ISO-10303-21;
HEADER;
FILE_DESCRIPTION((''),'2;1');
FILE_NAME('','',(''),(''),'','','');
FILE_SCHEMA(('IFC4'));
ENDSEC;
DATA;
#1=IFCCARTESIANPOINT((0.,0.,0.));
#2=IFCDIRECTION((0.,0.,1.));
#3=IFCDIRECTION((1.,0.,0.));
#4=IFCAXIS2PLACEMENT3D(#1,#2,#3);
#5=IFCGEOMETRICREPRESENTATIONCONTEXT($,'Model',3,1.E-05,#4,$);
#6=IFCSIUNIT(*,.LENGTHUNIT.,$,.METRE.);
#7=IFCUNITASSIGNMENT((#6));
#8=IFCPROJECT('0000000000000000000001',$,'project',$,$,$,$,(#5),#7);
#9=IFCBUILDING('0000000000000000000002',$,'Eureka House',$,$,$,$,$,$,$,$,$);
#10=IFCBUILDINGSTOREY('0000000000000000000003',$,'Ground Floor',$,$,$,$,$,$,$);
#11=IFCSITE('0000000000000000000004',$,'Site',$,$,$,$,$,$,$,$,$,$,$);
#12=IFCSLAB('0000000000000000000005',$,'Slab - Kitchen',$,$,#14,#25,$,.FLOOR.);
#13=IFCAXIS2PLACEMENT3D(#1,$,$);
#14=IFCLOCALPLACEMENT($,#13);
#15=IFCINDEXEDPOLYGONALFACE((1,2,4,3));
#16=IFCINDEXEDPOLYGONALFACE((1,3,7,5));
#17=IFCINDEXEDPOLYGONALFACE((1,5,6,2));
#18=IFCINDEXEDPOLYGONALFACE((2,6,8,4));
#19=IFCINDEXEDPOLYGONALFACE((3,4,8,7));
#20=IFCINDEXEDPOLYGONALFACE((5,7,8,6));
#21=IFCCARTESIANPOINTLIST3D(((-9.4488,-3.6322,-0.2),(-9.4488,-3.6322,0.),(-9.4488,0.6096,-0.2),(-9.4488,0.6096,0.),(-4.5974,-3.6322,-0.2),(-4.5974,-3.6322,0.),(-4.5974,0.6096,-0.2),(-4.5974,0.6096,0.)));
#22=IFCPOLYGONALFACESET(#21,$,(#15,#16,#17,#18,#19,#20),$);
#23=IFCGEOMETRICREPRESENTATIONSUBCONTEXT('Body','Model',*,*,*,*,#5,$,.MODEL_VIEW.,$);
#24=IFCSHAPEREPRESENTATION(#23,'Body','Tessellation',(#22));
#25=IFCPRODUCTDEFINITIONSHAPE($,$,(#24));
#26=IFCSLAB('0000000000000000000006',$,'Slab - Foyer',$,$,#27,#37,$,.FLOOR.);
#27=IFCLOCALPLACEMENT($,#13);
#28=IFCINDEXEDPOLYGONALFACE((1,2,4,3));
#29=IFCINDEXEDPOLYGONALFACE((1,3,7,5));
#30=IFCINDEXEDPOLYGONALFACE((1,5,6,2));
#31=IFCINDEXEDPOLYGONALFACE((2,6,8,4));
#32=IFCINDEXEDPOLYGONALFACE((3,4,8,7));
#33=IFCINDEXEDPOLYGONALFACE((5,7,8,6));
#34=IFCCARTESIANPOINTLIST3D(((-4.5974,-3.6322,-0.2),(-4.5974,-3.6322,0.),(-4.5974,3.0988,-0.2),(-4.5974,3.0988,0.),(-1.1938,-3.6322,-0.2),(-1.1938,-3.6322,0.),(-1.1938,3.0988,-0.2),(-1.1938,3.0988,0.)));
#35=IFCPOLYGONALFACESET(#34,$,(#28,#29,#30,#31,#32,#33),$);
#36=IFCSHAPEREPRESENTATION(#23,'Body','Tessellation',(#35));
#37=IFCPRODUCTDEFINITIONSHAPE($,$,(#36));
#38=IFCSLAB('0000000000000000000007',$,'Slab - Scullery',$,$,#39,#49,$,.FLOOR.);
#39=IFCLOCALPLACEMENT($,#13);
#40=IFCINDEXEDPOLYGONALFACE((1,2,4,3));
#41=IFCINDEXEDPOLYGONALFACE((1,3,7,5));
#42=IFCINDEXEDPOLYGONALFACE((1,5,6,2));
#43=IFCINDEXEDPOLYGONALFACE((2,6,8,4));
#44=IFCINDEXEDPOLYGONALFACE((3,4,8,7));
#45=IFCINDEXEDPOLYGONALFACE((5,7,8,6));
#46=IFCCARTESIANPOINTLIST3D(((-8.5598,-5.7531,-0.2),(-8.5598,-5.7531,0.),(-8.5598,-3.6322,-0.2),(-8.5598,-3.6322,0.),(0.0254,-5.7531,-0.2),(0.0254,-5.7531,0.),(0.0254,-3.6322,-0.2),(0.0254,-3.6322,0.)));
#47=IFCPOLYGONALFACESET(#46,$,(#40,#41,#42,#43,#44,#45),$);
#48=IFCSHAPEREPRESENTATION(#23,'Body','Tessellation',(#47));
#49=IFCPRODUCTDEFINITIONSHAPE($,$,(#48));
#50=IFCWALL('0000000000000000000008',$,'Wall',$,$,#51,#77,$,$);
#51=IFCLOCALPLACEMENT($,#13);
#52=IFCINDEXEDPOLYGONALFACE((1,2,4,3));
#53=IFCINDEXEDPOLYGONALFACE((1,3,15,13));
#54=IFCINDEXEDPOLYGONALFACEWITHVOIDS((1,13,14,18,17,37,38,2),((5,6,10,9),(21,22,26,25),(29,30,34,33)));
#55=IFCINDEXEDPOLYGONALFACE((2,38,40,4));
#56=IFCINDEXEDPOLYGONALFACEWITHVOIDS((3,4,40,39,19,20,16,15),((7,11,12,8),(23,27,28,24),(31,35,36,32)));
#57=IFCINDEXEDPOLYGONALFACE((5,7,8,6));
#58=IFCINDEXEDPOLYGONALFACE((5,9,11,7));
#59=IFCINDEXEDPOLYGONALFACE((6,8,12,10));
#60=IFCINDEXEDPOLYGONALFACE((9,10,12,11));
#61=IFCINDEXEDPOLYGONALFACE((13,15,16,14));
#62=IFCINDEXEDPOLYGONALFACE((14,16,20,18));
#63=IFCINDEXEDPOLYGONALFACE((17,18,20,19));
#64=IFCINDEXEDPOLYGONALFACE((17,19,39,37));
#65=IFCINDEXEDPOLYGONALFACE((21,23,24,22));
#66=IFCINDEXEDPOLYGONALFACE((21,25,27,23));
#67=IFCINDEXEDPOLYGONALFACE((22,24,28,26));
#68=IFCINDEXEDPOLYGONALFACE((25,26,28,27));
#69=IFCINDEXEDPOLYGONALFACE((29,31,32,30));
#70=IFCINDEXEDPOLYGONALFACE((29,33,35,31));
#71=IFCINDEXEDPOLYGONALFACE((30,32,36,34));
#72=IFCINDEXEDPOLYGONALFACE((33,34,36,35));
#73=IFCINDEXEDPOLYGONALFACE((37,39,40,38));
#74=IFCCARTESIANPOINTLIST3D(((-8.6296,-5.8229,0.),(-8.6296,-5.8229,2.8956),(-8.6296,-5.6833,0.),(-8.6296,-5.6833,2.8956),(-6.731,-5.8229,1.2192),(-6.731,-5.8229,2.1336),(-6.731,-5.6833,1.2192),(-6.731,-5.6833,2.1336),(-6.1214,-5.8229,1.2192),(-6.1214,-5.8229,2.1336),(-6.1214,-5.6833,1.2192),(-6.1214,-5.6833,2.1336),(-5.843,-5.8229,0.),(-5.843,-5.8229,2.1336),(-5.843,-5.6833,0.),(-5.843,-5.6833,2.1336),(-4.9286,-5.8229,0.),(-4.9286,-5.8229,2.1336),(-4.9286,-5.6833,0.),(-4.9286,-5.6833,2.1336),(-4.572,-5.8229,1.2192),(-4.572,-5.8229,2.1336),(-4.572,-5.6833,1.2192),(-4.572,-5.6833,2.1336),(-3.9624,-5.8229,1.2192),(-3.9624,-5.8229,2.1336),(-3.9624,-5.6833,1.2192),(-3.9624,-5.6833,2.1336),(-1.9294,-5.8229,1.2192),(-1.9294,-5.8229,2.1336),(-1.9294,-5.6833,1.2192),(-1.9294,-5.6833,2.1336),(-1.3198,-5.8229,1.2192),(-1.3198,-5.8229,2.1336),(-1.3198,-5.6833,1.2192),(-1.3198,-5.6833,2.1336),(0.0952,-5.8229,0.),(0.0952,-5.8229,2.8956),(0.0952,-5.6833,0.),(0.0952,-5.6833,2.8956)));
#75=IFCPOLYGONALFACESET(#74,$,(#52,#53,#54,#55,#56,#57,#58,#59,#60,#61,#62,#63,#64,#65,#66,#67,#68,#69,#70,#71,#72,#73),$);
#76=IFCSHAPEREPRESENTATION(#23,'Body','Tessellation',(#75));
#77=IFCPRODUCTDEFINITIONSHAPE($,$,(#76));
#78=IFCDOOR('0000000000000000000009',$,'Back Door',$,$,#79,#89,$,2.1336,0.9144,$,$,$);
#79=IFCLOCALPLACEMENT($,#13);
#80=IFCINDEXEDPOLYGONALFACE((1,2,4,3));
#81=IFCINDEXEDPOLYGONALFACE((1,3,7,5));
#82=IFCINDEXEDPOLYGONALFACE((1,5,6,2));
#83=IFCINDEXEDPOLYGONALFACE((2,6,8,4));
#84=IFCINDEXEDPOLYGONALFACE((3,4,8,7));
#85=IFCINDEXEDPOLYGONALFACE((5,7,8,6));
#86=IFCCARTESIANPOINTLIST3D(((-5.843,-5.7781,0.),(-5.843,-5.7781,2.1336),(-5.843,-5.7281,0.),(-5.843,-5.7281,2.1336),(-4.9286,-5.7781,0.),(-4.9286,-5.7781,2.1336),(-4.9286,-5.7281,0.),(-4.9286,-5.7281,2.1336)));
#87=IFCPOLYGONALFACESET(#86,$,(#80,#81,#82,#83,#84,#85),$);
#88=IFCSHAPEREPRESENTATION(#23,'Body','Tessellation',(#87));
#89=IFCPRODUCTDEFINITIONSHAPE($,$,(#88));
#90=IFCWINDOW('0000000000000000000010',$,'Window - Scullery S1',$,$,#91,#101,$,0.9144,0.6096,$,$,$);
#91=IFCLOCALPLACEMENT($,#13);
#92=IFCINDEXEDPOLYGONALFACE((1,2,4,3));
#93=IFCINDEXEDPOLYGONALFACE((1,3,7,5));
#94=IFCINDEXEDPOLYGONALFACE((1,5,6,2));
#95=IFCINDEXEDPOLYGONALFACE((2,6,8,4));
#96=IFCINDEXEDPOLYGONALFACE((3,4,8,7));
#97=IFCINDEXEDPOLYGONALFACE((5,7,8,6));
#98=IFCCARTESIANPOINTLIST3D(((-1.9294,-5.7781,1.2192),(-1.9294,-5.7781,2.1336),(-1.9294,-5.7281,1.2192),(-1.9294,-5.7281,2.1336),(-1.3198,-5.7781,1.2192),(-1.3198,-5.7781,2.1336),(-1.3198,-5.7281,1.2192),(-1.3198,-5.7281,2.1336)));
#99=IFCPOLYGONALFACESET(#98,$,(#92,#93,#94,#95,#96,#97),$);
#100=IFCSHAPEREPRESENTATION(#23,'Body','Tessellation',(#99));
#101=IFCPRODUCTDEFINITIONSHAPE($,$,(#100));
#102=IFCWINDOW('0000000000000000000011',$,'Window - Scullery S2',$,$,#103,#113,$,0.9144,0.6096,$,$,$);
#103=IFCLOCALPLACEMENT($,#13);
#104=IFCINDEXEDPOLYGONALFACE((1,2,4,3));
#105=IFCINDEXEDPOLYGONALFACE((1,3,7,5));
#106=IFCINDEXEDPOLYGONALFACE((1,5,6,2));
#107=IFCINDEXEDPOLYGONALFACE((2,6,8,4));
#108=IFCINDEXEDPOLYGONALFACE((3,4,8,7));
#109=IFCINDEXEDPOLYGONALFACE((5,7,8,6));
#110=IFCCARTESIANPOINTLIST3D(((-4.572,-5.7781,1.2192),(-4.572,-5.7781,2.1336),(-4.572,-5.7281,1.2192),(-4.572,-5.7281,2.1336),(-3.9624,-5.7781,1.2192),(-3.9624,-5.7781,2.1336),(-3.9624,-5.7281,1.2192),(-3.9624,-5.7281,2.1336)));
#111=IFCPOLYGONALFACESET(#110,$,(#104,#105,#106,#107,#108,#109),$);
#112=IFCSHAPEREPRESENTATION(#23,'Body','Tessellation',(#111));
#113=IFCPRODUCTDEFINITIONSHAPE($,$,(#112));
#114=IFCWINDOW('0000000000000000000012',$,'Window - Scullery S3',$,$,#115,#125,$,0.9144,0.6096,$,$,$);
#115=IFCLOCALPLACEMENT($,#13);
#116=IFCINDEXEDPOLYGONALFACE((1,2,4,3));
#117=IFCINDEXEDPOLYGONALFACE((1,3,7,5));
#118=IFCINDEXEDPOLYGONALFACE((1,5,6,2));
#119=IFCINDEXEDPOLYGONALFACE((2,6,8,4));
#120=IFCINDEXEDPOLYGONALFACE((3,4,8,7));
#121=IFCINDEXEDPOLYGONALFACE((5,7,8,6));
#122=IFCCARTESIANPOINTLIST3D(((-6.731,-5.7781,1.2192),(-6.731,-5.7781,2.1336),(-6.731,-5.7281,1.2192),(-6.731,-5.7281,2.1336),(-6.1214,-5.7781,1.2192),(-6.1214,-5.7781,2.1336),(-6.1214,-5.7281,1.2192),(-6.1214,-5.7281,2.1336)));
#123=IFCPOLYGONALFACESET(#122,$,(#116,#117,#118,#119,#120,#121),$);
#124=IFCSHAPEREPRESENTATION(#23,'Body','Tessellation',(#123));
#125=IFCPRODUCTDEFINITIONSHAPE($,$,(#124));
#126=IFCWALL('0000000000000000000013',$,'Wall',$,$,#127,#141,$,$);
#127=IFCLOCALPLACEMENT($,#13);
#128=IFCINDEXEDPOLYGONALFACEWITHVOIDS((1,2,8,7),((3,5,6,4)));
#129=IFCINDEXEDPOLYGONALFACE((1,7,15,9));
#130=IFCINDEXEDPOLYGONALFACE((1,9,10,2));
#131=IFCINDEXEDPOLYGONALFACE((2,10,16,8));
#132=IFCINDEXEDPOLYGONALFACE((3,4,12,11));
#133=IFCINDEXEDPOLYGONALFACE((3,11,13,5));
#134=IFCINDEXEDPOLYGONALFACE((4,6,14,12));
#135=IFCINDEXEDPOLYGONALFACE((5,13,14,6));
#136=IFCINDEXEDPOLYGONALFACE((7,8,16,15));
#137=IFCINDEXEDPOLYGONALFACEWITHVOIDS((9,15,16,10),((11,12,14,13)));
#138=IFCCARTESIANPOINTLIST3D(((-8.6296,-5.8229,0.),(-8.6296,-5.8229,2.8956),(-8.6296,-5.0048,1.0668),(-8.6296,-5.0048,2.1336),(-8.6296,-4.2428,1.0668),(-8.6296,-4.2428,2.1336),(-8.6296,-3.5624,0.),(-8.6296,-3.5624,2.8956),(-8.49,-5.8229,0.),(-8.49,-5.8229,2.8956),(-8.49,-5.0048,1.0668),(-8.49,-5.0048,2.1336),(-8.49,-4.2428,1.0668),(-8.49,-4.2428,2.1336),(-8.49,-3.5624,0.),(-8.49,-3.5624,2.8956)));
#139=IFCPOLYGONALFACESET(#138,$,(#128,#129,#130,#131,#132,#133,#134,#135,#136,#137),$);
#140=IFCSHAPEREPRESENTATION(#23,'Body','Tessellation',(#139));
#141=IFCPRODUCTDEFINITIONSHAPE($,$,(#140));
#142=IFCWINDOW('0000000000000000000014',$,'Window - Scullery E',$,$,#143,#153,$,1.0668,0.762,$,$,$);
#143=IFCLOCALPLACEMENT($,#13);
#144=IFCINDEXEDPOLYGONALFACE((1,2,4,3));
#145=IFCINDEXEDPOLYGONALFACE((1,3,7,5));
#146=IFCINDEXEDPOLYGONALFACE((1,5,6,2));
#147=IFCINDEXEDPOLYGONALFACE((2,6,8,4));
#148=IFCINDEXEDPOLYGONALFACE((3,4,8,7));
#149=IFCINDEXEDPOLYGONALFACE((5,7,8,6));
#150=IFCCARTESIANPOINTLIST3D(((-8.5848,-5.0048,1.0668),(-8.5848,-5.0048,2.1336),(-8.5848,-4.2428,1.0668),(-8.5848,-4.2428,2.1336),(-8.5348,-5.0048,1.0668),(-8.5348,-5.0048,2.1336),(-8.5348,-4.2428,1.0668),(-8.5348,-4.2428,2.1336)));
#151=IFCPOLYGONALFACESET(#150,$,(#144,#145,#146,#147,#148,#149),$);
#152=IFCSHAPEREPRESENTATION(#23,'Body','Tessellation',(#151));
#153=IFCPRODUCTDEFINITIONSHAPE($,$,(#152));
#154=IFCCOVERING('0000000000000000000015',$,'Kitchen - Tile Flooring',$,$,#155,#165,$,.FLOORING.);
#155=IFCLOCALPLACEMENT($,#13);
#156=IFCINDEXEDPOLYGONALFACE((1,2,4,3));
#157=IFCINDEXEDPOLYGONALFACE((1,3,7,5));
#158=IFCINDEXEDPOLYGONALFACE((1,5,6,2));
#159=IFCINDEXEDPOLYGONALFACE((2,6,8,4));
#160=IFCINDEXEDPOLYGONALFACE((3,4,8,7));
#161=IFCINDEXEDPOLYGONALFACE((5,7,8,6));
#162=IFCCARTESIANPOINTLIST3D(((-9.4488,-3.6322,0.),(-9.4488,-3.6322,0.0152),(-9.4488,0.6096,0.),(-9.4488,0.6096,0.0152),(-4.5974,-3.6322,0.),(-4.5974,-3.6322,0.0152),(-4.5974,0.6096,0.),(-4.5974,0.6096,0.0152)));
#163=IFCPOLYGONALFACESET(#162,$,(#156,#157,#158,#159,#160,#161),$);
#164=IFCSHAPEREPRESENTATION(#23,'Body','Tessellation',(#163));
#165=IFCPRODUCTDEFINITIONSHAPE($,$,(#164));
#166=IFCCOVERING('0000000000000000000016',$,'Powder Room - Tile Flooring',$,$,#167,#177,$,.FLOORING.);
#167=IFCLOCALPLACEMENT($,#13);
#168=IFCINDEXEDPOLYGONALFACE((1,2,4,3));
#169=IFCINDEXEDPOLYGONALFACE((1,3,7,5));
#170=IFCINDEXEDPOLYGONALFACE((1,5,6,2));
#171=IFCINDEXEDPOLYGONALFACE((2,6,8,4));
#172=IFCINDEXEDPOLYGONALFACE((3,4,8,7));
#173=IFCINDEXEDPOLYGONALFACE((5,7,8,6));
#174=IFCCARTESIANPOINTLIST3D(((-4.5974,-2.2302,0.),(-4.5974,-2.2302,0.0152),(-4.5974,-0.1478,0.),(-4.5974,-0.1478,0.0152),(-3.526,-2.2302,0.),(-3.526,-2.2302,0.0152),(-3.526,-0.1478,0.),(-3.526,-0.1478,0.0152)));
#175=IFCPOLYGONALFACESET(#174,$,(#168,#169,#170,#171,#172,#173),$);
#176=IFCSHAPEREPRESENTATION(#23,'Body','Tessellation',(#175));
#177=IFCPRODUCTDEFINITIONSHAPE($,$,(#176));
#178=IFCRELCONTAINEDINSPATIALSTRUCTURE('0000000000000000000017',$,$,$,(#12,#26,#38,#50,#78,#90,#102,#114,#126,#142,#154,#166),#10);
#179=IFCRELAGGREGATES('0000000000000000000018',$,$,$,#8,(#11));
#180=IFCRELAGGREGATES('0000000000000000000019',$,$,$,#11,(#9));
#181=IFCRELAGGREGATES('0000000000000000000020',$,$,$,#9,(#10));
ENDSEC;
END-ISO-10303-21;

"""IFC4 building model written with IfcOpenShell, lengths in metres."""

from ifc_helpers import new_model, si_unit, frame, origin, origin_with_axes, origin_2d, place, context, subcontext, project, spatial, rectangle, extrude, element, fill, save


model = new_model("IFC4")

# Units and contexts
model_context = context("Model", 3, precision=1e-05, world=origin_with_axes())
body_context = subcontext(model_context, "Body", "Model", "MODEL_VIEW")
ifc_project = project(units=[si_unit("LENGTHUNIT", "METRE")], contexts=[model_context])

# Site, building, storey
site = spatial("IfcSite", under=ifc_project, Name="Site")
building = spatial("IfcBuilding", under=site, Name="Eureka House")
storey = spatial("IfcBuildingStorey", under=building, Name="Ground Floor")

# Slabs
slab_1_placement = place(None, frame((-7.0231, -1.5113, -0.2), z_axis=(0.0, 0.0, 1.0), x_axis=(1.0, 0.0, 0.0)))
element("IfcSlab", 1, at=slab_1_placement, inside=storey, Name="Slab - Kitchen", PredefinedType="FLOOR", context=body_context, shape_type="SweptSolid", body=[
    extrude(rectangle(XDim=4.8514, YDim=4.2418, at=origin_2d()), origin(), (0.0, 0.0, 1.0), 0.2),
])
slab_2_placement = place(None, frame((-2.8956, -0.2667, -0.2), z_axis=(0.0, 0.0, 1.0), x_axis=(1.0, 0.0, 0.0)))
element("IfcSlab", 2, at=slab_2_placement, inside=storey, Name="Slab - Foyer", PredefinedType="FLOOR", context=body_context, shape_type="SweptSolid", body=[
    extrude(rectangle(XDim=3.4036, YDim=6.731, at=origin_2d()), origin(), (0.0, 0.0, 1.0), 0.2),
])
slab_3_placement = place(None, frame((-4.2672, -4.6927, -0.2), z_axis=(0.0, 0.0, 1.0), x_axis=(1.0, 0.0, 0.0)))
element("IfcSlab", 3, at=slab_3_placement, inside=storey, Name="Slab - Scullery", PredefinedType="FLOOR", context=body_context, shape_type="SweptSolid", body=[
    extrude(rectangle(XDim=8.5852, YDim=2.1209, at=origin_2d()), origin(), (0.0, 0.0, 1.0), 0.2),
])

# Wall, openings, door, windows
wall_1_placement = place(None, frame((-4.2672, -5.7531, 0.0), z_axis=(0.0, 0.0, 1.0), x_axis=(1.0, 0.0, 0.0)))
wall_1 = element("IfcWall", 4, at=wall_1_placement, inside=storey, Name="Wall", context=body_context, shape_type="SweptSolid", body=[
    extrude(rectangle(XDim=8.7249, YDim=0.1397, at=origin_2d()), origin(), (0.0, 0.0, 1.0), 2.8956),
])
opening_1_placement = place(wall_1_placement, frame((-1.1186, 0.0, 0.0), z_axis=(0.0, 0.0, 1.0), x_axis=(1.0, 0.0, 0.0)))
opening_1 = element("IfcOpeningElement", 5, at=opening_1_placement, cuts=wall_1, context=body_context, shape_type="SweptSolid", body=[
    extrude(rectangle(XDim=0.9144, YDim=0.2397, at=origin_2d()), origin(), (0.0, 0.0, 1.0), 2.1336),
])
opening_2_placement = place(wall_1_placement, frame((2.6426, 0.0, 1.2192), z_axis=(0.0, 0.0, 1.0), x_axis=(1.0, 0.0, 0.0)))
opening_2 = element("IfcOpeningElement", 6, at=opening_2_placement, cuts=wall_1, context=body_context, shape_type="SweptSolid", body=[
    extrude(rectangle(XDim=0.6096, YDim=0.2397, at=origin_2d()), origin(), (0.0, 0.0, 1.0), 0.9144),
])
opening_3_placement = place(wall_1_placement, frame((0.0, 0.0, 1.2192), z_axis=(0.0, 0.0, 1.0), x_axis=(1.0, 0.0, 0.0)))
opening_3 = element("IfcOpeningElement", 7, at=opening_3_placement, cuts=wall_1, context=body_context, shape_type="SweptSolid", body=[
    extrude(rectangle(XDim=0.6096, YDim=0.2397, at=origin_2d()), origin(), (0.0, 0.0, 1.0), 0.9144),
])
opening_4_placement = place(wall_1_placement, frame((-2.159, 0.0, 1.2192), z_axis=(0.0, 0.0, 1.0), x_axis=(1.0, 0.0, 0.0)))
opening_4 = element("IfcOpeningElement", 8, at=opening_4_placement, cuts=wall_1, context=body_context, shape_type="SweptSolid", body=[
    extrude(rectangle(XDim=0.6096, YDim=0.2397, at=origin_2d()), origin(), (0.0, 0.0, 1.0), 0.9144),
])
door_placement = place(opening_1_placement, origin_with_axes())
door = element("IfcDoor", 9, at=door_placement, inside=storey, Name="Back Door", OverallHeight=2.1336, OverallWidth=0.9144, context=body_context, shape_type="SweptSolid", body=[
    extrude(rectangle(XDim=0.9144, YDim=0.05, at=origin_2d()), origin(), (0.0, 0.0, 1.0), 2.1336),
])
fill(opening_1, door)
window_1_placement = place(opening_2_placement, origin_with_axes())
window_1 = element("IfcWindow", 10, at=window_1_placement, inside=storey, Name="Window - Scullery S1", OverallHeight=0.9144, OverallWidth=0.6096, context=body_context, shape_type="SweptSolid", body=[
    extrude(rectangle(XDim=0.6096, YDim=0.05, at=origin_2d()), origin(), (0.0, 0.0, 1.0), 0.9144),
])
fill(opening_2, window_1)
window_2_placement = place(opening_3_placement, origin_with_axes())
window_2 = element("IfcWindow", 11, at=window_2_placement, inside=storey, Name="Window - Scullery S2", OverallHeight=0.9144, OverallWidth=0.6096, context=body_context, shape_type="SweptSolid", body=[
    extrude(rectangle(XDim=0.6096, YDim=0.05, at=origin_2d()), origin(), (0.0, 0.0, 1.0), 0.9144),
])
fill(opening_3, window_2)
window_3_placement = place(opening_4_placement, origin_with_axes())
window_3 = element("IfcWindow", 12, at=window_3_placement, inside=storey, Name="Window - Scullery S3", OverallHeight=0.9144, OverallWidth=0.6096, context=body_context, shape_type="SweptSolid", body=[
    extrude(rectangle(XDim=0.6096, YDim=0.05, at=origin_2d()), origin(), (0.0, 0.0, 1.0), 0.9144),
])
fill(opening_4, window_3)

# Wall, opening, window
wall_2_placement = place(None, frame((-8.5598, -4.6927, 0.0), z_axis=(0.0, 0.0, 1.0), x_axis=(1.0, 0.0, 0.0)))
wall_2 = element("IfcWall", 13, at=wall_2_placement, inside=storey, Name="Wall", context=body_context, shape_type="SweptSolid", body=[
    extrude(rectangle(XDim=0.1397, YDim=2.2606, at=origin_2d()), origin(), (0.0, 0.0, 1.0), 2.8956),
])
opening_5_placement = place(wall_2_placement, frame((0.0, 0.0688, 1.0668), z_axis=(0.0, 0.0, 1.0), x_axis=(1.0, 0.0, 0.0)))
opening_5 = element("IfcOpeningElement", 14, at=opening_5_placement, cuts=wall_2, context=body_context, shape_type="SweptSolid", body=[
    extrude(rectangle(XDim=0.2397, YDim=0.762, at=origin_2d()), origin(), (0.0, 0.0, 1.0), 1.0668),
])
window_4_placement = place(opening_5_placement, origin_with_axes())
window_4 = element("IfcWindow", 15, at=window_4_placement, inside=storey, Name="Window - Scullery E", OverallHeight=1.0668, OverallWidth=0.762, context=body_context, shape_type="SweptSolid", body=[
    extrude(rectangle(XDim=0.05, YDim=0.762, at=origin_2d()), origin(), (0.0, 0.0, 1.0), 1.0668),
])
fill(opening_5, window_4)

# Coverings
covering_1_placement = place(None, frame((-7.0231, -1.5113, 0.0), z_axis=(0.0, 0.0, 1.0), x_axis=(1.0, 0.0, 0.0)))
element("IfcCovering", 16, at=covering_1_placement, inside=storey, Name="Kitchen - Tile Flooring", PredefinedType="FLOORING", context=body_context, shape_type="SweptSolid", body=[
    extrude(rectangle(XDim=4.8514, YDim=4.2418, at=origin_2d()), origin(), (0.0, 0.0, 1.0), 0.0152),
])
covering_2_placement = place(None, frame((-4.0617, -1.189, 0.0), z_axis=(0.0, 0.0, 1.0), x_axis=(1.0, 0.0, 0.0)))
element("IfcCovering", 17, at=covering_2_placement, inside=storey, Name="Powder Room - Tile Flooring", PredefinedType="FLOORING", context=body_context, shape_type="SweptSolid", body=[
    extrude(rectangle(XDim=1.0714, YDim=2.0824, at=origin_2d()), origin(), (0.0, 0.0, 1.0), 0.0152),
])

save(model, "model.ifc")
